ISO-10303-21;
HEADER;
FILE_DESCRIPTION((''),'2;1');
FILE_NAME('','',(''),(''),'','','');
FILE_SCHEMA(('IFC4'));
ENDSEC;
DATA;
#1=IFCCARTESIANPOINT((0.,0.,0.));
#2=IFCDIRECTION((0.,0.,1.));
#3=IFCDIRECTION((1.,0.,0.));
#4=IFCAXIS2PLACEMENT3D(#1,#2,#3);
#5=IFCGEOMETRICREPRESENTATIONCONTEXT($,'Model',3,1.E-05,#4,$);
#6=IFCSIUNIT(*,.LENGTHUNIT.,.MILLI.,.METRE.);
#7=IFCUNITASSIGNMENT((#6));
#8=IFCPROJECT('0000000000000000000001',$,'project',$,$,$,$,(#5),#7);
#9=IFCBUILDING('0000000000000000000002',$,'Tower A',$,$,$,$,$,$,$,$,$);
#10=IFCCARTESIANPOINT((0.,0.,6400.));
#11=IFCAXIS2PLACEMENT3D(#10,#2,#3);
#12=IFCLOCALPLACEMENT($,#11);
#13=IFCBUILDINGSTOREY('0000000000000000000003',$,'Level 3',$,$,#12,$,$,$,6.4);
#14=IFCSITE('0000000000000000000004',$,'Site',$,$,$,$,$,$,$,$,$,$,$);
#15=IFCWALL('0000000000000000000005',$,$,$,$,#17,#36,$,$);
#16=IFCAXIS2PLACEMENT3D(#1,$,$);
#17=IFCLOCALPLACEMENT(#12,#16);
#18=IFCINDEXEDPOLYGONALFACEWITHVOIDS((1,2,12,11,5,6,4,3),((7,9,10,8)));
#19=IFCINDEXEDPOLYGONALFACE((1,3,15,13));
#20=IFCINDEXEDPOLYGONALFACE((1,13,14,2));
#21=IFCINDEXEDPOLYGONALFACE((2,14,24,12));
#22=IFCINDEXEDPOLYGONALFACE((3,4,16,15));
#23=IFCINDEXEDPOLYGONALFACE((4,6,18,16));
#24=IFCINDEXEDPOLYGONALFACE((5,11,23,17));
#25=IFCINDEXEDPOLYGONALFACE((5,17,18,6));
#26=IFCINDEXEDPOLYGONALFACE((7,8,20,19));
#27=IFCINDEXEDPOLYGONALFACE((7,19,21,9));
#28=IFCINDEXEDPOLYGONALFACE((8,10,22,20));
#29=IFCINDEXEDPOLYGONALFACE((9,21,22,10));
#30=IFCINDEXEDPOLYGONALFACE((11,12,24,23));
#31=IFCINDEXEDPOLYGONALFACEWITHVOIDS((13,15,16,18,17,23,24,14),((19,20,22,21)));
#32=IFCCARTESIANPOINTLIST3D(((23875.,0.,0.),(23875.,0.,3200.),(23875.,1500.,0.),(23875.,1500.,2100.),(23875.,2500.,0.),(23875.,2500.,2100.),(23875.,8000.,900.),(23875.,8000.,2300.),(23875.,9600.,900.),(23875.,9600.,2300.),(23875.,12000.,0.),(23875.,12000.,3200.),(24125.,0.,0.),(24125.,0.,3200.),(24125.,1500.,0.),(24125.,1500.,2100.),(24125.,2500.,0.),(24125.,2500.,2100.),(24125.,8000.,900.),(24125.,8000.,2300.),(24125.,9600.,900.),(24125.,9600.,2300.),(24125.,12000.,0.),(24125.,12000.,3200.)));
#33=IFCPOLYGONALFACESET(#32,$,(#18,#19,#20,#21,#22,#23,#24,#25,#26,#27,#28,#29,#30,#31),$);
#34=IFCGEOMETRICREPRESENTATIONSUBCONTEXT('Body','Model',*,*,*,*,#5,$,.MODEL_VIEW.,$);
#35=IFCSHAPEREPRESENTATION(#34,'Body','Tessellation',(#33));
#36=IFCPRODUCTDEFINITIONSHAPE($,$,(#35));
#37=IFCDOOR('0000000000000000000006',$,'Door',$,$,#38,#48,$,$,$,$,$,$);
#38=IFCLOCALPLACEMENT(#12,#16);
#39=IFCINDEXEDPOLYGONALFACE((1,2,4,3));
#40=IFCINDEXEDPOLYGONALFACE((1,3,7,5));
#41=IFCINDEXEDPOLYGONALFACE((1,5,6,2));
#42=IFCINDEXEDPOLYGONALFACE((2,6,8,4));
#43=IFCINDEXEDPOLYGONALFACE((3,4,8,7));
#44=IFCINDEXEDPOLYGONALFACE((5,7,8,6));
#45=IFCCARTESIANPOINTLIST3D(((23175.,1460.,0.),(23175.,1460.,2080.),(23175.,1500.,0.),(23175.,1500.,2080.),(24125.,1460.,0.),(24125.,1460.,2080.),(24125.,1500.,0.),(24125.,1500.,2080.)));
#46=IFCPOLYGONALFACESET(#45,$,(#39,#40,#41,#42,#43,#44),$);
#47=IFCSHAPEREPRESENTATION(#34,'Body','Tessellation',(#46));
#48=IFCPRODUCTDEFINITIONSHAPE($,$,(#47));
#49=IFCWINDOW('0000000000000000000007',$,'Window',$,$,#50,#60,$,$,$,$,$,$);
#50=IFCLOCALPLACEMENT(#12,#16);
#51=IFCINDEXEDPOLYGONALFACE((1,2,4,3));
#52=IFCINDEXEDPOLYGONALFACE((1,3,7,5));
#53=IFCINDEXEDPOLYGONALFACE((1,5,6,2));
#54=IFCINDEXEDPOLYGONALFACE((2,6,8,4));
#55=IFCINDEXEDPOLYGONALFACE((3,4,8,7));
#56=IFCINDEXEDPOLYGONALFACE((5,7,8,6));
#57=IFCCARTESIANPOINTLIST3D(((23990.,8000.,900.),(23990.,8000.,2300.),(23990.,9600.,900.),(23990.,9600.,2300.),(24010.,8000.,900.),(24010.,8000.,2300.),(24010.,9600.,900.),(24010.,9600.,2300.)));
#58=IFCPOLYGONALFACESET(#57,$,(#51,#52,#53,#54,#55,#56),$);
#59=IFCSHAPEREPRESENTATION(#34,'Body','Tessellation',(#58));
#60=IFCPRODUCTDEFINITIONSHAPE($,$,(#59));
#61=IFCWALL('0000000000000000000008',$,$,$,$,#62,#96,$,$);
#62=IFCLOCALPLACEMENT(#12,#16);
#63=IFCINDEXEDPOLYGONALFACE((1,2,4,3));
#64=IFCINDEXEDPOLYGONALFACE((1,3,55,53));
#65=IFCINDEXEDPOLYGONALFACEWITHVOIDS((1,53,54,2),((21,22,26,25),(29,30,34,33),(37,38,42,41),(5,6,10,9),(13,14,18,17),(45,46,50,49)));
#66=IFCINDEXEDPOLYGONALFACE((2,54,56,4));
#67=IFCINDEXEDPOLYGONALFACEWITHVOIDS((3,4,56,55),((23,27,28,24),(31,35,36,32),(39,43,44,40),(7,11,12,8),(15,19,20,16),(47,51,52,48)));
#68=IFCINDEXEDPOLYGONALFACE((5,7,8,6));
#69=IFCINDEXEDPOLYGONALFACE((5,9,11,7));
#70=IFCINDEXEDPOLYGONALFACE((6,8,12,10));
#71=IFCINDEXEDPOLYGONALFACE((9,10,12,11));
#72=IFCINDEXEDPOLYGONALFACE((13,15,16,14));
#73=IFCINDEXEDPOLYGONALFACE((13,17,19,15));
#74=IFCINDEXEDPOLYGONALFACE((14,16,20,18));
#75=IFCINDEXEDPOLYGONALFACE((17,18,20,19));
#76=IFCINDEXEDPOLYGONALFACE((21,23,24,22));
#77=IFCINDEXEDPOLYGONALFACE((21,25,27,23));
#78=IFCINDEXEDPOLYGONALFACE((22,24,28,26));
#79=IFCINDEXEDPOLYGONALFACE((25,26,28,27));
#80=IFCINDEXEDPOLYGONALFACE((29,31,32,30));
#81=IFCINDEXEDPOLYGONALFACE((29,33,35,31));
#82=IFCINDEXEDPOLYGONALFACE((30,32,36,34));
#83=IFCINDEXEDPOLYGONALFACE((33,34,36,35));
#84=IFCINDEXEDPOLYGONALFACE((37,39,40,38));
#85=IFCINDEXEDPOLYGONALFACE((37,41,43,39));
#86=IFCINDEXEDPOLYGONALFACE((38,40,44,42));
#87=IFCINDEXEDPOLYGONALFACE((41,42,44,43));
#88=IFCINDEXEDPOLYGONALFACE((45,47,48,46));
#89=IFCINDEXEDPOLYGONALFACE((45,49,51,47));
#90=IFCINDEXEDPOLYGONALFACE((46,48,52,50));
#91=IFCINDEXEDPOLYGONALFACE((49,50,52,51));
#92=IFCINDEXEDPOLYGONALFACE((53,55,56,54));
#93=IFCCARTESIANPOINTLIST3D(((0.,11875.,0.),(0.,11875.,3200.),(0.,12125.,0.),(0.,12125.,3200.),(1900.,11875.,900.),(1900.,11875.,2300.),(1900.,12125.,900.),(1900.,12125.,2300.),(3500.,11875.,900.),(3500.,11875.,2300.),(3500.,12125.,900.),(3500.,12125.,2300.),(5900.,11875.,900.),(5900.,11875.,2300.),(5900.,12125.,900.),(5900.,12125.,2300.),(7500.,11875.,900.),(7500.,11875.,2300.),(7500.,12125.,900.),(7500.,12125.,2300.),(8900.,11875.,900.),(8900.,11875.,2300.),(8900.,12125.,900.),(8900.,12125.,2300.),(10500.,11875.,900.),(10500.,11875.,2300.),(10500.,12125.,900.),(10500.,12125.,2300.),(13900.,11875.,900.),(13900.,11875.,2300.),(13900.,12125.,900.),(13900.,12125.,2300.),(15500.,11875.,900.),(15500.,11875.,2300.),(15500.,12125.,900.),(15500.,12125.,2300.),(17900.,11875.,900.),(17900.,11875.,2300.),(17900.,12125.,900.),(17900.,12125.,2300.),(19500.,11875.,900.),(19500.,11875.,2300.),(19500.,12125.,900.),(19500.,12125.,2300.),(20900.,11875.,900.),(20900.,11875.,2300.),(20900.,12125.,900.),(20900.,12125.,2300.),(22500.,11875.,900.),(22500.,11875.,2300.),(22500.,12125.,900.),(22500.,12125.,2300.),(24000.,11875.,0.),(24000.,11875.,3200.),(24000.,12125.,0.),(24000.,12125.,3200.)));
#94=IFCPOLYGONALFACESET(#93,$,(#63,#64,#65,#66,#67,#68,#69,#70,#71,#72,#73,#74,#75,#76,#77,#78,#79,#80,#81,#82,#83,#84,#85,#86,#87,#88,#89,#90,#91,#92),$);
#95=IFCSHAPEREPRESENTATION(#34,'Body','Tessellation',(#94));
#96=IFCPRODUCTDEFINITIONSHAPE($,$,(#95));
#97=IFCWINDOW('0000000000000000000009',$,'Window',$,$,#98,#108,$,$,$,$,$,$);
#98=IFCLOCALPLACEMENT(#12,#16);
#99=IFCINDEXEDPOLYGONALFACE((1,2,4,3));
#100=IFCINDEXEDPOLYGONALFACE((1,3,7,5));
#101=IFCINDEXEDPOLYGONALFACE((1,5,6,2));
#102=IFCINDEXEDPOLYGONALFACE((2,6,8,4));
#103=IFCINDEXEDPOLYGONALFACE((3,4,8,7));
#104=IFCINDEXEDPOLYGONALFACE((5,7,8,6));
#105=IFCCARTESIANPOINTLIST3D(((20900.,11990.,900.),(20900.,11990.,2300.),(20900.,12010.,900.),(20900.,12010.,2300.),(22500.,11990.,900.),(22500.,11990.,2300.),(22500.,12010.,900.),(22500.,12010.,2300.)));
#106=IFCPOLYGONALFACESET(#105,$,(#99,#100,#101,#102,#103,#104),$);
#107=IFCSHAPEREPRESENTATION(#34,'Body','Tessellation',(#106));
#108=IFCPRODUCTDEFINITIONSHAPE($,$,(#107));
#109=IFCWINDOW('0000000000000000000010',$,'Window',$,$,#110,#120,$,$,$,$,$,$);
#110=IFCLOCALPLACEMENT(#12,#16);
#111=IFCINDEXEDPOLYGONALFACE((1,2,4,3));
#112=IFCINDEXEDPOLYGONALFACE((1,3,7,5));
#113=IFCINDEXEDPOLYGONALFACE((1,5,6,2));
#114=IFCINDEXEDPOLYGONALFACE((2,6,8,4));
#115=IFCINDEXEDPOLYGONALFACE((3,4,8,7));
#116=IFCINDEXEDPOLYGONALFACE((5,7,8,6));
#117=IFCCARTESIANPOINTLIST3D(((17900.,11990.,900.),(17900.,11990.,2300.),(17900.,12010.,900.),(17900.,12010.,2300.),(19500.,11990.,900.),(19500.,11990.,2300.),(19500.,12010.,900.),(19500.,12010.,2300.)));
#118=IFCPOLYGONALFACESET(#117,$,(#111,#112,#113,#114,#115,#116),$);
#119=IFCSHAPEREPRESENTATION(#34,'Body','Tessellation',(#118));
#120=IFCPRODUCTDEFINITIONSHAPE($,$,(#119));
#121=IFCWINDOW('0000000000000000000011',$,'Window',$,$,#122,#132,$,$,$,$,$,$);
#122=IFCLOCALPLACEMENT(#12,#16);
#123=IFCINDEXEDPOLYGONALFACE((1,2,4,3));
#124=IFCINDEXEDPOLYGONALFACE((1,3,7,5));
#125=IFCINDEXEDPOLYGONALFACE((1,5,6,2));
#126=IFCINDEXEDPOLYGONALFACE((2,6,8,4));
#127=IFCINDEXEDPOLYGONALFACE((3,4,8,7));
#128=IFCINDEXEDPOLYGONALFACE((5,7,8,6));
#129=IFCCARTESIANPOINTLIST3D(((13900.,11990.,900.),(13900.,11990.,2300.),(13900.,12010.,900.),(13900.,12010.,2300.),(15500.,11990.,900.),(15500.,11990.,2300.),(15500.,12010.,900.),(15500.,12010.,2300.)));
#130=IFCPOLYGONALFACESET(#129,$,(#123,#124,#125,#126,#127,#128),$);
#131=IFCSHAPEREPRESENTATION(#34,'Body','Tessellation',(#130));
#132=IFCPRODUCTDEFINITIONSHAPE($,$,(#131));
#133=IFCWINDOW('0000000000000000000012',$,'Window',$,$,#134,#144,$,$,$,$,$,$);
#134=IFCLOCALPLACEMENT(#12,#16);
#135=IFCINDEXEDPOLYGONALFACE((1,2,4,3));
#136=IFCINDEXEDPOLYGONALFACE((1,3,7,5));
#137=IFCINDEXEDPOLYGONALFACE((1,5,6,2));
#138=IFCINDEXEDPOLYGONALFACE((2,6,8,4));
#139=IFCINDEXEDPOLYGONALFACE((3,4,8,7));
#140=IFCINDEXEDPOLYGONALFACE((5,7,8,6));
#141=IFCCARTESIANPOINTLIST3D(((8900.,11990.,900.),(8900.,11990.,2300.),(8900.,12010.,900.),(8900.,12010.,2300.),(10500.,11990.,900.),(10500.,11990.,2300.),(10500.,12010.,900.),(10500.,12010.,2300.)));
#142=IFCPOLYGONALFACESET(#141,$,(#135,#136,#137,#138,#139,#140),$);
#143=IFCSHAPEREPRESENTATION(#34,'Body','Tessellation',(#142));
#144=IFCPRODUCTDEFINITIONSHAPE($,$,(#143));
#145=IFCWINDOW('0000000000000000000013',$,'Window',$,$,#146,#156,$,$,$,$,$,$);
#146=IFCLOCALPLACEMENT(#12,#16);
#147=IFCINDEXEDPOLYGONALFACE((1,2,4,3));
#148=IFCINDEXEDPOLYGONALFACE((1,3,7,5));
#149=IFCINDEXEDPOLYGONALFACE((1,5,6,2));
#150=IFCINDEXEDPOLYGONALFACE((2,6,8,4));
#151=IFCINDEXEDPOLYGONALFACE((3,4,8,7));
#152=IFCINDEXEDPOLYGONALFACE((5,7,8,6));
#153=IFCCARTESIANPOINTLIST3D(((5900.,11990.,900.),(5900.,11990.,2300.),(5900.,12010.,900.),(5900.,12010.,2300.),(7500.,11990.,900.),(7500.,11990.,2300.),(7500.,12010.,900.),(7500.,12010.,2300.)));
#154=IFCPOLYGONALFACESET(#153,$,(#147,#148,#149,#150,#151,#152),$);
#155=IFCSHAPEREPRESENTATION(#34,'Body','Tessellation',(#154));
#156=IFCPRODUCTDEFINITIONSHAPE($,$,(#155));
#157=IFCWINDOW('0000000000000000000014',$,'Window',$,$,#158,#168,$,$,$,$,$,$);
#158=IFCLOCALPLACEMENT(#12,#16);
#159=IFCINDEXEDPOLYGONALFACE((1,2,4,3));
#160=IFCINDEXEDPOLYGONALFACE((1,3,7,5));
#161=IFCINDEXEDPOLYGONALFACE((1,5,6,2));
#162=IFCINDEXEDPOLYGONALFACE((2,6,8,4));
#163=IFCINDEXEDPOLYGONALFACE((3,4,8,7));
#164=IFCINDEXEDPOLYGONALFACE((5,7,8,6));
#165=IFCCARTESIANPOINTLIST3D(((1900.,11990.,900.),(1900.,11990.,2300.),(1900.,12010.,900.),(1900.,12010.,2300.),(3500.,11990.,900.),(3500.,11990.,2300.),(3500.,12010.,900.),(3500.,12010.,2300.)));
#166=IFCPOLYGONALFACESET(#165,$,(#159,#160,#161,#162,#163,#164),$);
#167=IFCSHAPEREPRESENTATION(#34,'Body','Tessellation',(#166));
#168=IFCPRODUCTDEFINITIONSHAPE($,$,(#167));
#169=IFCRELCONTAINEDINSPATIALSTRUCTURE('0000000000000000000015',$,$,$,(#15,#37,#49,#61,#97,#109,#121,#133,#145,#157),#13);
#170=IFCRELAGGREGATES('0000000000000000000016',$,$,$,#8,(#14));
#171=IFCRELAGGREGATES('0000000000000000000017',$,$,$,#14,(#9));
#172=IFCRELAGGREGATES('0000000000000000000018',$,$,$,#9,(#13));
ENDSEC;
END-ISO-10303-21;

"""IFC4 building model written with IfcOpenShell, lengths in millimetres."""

from ifc_helpers import new_model, si_unit, frame, origin_with_axes, place, context, subcontext, project, spatial, indexed_curve, outline, extrude, element, fill, save


model = new_model("IFC4")

# Units and contexts
model_context = context("Model", 3, precision=1e-05, world=origin_with_axes())
body_context = subcontext(model_context, "Body", "Model", "MODEL_VIEW")
ifc_project = project(units=[si_unit("LENGTHUNIT", "METRE", prefix="MILLI")], contexts=[model_context])

# Site, building, storey
site = spatial("IfcSite", under=ifc_project, Name="Site")
building = spatial("IfcBuilding", under=site, Name="Tower A")
storey_placement = place(None, frame((0.0, 0.0, 6400.0), z_axis=(0.0, 0.0, 1.0), x_axis=(1.0, 0.0, 0.0)))
storey = spatial("IfcBuildingStorey", under=building, at=storey_placement, Name="Level 3", Elevation=6.4)

# Wall, openings, door, window
wall_1_placement = place(storey_placement, frame((24125.0, 0.0, 0.0), z_axis=(0.0, 0.0, 1.0), x_axis=(0.0, 1.0, 0.0)))
wall_1 = element("IfcWall", 1, at=wall_1_placement, inside=storey, context=body_context, shape_type="SweptSolid", body=[
    extrude(outline(indexed_curve([(0.0, 0.0), (0.0, 250.0), (12000.0, 250.0), (12000.0, 0.0), (0.0, 0.0)], self_intersect=False)), origin_with_axes(), (0.0, 0.0, 1.0), 3200.0),
])
opening_1_placement = place(wall_1_placement, frame((1500.0, 0.0, 0.0), z_axis=(0.0, 0.0, 1.0), x_axis=(1.0, 0.0, 0.0)))
opening_1 = element("IfcOpeningElement", 2, at=opening_1_placement, cuts=wall_1, context=body_context, shape_type="SweptSolid", body=[
    extrude(outline(indexed_curve([(0.0, 0.0), (0.0, 250.0), (1000.0, 250.0), (1000.0, 0.0), (0.0, 0.0)], self_intersect=False)), origin_with_axes(), (0.0, 0.0, 1.0), 2100.0),
])
opening_2_placement = place(wall_1_placement, frame((8000.0, 0.0, 900.0), z_axis=(0.0, 0.0, 1.0), x_axis=(1.0, 0.0, 0.0)))
opening_2 = element("IfcOpeningElement", 3, at=opening_2_placement, cuts=wall_1, context=body_context, shape_type="SweptSolid", body=[
    extrude(outline(indexed_curve([(0.0, 0.0), (0.0, 250.0), (1600.0, 250.0), (1600.0, 0.0), (0.0, 0.0)], self_intersect=False)), origin_with_axes(), (0.0, 0.0, 1.0), 1400.0),
])
door_1_placement = place(storey_placement, frame((24125.0, 1500.0, 0.0), z_axis=(0.0, 0.0, 1.0), x_axis=(-1.0, 0.0, 0.0)))
door_1 = element("IfcDoor", 4, at=door_1_placement, inside=storey, Name="Door", context=body_context, shape_type="SweptSolid", body=[
    extrude(outline(indexed_curve([(0.0, 0.0), (0.0, 40.0), (950.0, 40.0), (950.0, 0.0), (0.0, 0.0)], self_intersect=False)), origin_with_axes(), (0.0, 0.0, 1.0), 2080.0),
])
fill(opening_1, door_1)
window_1_placement = place(storey_placement, frame((24010.0, 8000.0, 900.0), z_axis=(0.0, 0.0, 1.0), x_axis=(0.0, 1.0, 0.0)))
window_1 = element("IfcWindow", 5, at=window_1_placement, inside=storey, Name="Window", context=body_context, shape_type="SweptSolid", body=[
    extrude(outline(indexed_curve([(0.0, 0.0), (0.0, 20.0), (1600.0, 20.0), (1600.0, 0.0), (0.0, 0.0)], self_intersect=False)), origin_with_axes(), (0.0, 0.0, 1.0), 1400.0),
])
fill(opening_2, window_1)

# Wall, openings, windows
wall_2_placement = place(storey_placement, frame((24000.0, 12125.0, 0.0), z_axis=(0.0, 0.0, 1.0), x_axis=(-1.0, 0.0, 0.0)))
wall_2 = element("IfcWall", 6, at=wall_2_placement, inside=storey, context=body_context, shape_type="SweptSolid", body=[
    extrude(outline(indexed_curve([(0.0, 0.0), (0.0, 250.0), (24000.0, 250.0), (24000.0, 0.0), (0.0, 0.0)], self_intersect=False)), origin_with_axes(), (0.0, 0.0, 1.0), 3200.0),
])
opening_3_placement = place(wall_2_placement, frame((1500.0, 0.0, 900.0), z_axis=(0.0, 0.0, 1.0), x_axis=(1.0, 0.0, 0.0)))
opening_3 = element("IfcOpeningElement", 7, at=opening_3_placement, cuts=wall_2, context=body_context, shape_type="SweptSolid", body=[
    extrude(outline(indexed_curve([(0.0, 0.0), (0.0, 250.0), (1600.0, 250.0), (1600.0, 0.0), (0.0, 0.0)], self_intersect=False)), origin_with_axes(), (0.0, 0.0, 1.0), 1400.0),
])
opening_4_placement = place(wall_2_placement, frame((4500.0, 0.0, 900.0), z_axis=(0.0, 0.0, 1.0), x_axis=(1.0, 0.0, 0.0)))
opening_4 = element("IfcOpeningElement", 8, at=opening_4_placement, cuts=wall_2, context=body_context, shape_type="SweptSolid", body=[
    extrude(outline(indexed_curve([(0.0, 0.0), (0.0, 250.0), (1600.0, 250.0), (1600.0, 0.0), (0.0, 0.0)], self_intersect=False)), origin_with_axes(), (0.0, 0.0, 1.0), 1400.0),
])
opening_5_placement = place(wall_2_placement, frame((8500.0, 0.0, 900.0), z_axis=(0.0, 0.0, 1.0), x_axis=(1.0, 0.0, 0.0)))
opening_5 = element("IfcOpeningElement", 9, at=opening_5_placement, cuts=wall_2, context=body_context, shape_type="SweptSolid", body=[
    extrude(outline(indexed_curve([(0.0, 0.0), (0.0, 250.0), (1600.0, 250.0), (1600.0, 0.0), (0.0, 0.0)], self_intersect=False)), origin_with_axes(), (0.0, 0.0, 1.0), 1400.0),
])
opening_6_placement = place(wall_2_placement, frame((13500.0, 0.0, 900.0), z_axis=(0.0, 0.0, 1.0), x_axis=(1.0, 0.0, 0.0)))
opening_6 = element("IfcOpeningElement", 10, at=opening_6_placement, cuts=wall_2, context=body_context, shape_type="SweptSolid", body=[
    extrude(outline(indexed_curve([(0.0, 0.0), (0.0, 250.0), (1600.0, 250.0), (1600.0, 0.0), (0.0, 0.0)], self_intersect=False)), origin_with_axes(), (0.0, 0.0, 1.0), 1400.0),
])
opening_7_placement = place(wall_2_placement, frame((16500.0, 0.0, 900.0), z_axis=(0.0, 0.0, 1.0), x_axis=(1.0, 0.0, 0.0)))
opening_7 = element("IfcOpeningElement", 11, at=opening_7_placement, cuts=wall_2, context=body_context, shape_type="SweptSolid", body=[
    extrude(outline(indexed_curve([(0.0, 0.0), (0.0, 250.0), (1600.0, 250.0), (1600.0, 0.0), (0.0, 0.0)], self_intersect=False)), origin_with_axes(), (0.0, 0.0, 1.0), 1400.0),
])
opening_8_placement = place(wall_2_placement, frame((20500.0, 0.0, 900.0), z_axis=(0.0, 0.0, 1.0), x_axis=(1.0, 0.0, 0.0)))
opening_8 = element("IfcOpeningElement", 12, at=opening_8_placement, cuts=wall_2, context=body_context, shape_type="SweptSolid", body=[
    extrude(outline(indexed_curve([(0.0, 0.0), (0.0, 250.0), (1600.0, 250.0), (1600.0, 0.0), (0.0, 0.0)], self_intersect=False)), origin_with_axes(), (0.0, 0.0, 1.0), 1400.0),
])
window_2_placement = place(storey_placement, frame((22500.0, 12010.0, 900.0), z_axis=(0.0, 0.0, 1.0), x_axis=(-1.0, 0.0, 0.0)))
window_2 = element("IfcWindow", 13, at=window_2_placement, inside=storey, Name="Window", context=body_context, shape_type="SweptSolid", body=[
    extrude(outline(indexed_curve([(0.0, 0.0), (0.0, 20.0), (1600.0, 20.0), (1600.0, 0.0), (0.0, 0.0)], self_intersect=False)), origin_with_axes(), (0.0, 0.0, 1.0), 1400.0),
])
fill(opening_3, window_2)
window_3_placement = place(storey_placement, frame((19500.0, 12010.0, 900.0), z_axis=(0.0, 0.0, 1.0), x_axis=(-1.0, 0.0, 0.0)))
window_3 = element("IfcWindow", 14, at=window_3_placement, inside=storey, Name="Window", context=body_context, shape_type="SweptSolid", body=[
    extrude(outline(indexed_curve([(0.0, 0.0), (0.0, 20.0), (1600.0, 20.0), (1600.0, 0.0), (0.0, 0.0)], self_intersect=False)), origin_with_axes(), (0.0, 0.0, 1.0), 1400.0),
])
fill(opening_4, window_3)
window_4_placement = place(storey_placement, frame((15500.0, 12010.0, 900.0), z_axis=(0.0, 0.0, 1.0), x_axis=(-1.0, 0.0, 0.0)))
window_4 = element("IfcWindow", 15, at=window_4_placement, inside=storey, Name="Window", context=body_context, shape_type="SweptSolid", body=[
    extrude(outline(indexed_curve([(0.0, 0.0), (0.0, 20.0), (1600.0, 20.0), (1600.0, 0.0), (0.0, 0.0)], self_intersect=False)), origin_with_axes(), (0.0, 0.0, 1.0), 1400.0),
])
fill(opening_5, window_4)
window_5_placement = place(storey_placement, frame((10500.0, 12010.0, 900.0), z_axis=(0.0, 0.0, 1.0), x_axis=(-1.0, 0.0, 0.0)))
window_5 = element("IfcWindow", 16, at=window_5_placement, inside=storey, Name="Window", context=body_context, shape_type="SweptSolid", body=[
    extrude(outline(indexed_curve([(0.0, 0.0), (0.0, 20.0), (1600.0, 20.0), (1600.0, 0.0), (0.0, 0.0)], self_intersect=False)), origin_with_axes(), (0.0, 0.0, 1.0), 1400.0),
])
fill(opening_6, window_5)
window_6_placement = place(storey_placement, frame((7500.0, 12010.0, 900.0), z_axis=(0.0, 0.0, 1.0), x_axis=(-1.0, 0.0, 0.0)))
window_6 = element("IfcWindow", 17, at=window_6_placement, inside=storey, Name="Window", context=body_context, shape_type="SweptSolid", body=[
    extrude(outline(indexed_curve([(0.0, 0.0), (0.0, 20.0), (1600.0, 20.0), (1600.0, 0.0), (0.0, 0.0)], self_intersect=False)), origin_with_axes(), (0.0, 0.0, 1.0), 1400.0),
])
fill(opening_7, window_6)
window_7_placement = place(storey_placement, frame((3500.0, 12010.0, 900.0), z_axis=(0.0, 0.0, 1.0), x_axis=(-1.0, 0.0, 0.0)))
window_7 = element("IfcWindow", 18, at=window_7_placement, inside=storey, Name="Window", context=body_context, shape_type="SweptSolid", body=[
    extrude(outline(indexed_curve([(0.0, 0.0), (0.0, 20.0), (1600.0, 20.0), (1600.0, 0.0), (0.0, 0.0)], self_intersect=False)), origin_with_axes(), (0.0, 0.0, 1.0), 1400.0),
])
fill(opening_8, window_7)

save(model, "model.ifc")
